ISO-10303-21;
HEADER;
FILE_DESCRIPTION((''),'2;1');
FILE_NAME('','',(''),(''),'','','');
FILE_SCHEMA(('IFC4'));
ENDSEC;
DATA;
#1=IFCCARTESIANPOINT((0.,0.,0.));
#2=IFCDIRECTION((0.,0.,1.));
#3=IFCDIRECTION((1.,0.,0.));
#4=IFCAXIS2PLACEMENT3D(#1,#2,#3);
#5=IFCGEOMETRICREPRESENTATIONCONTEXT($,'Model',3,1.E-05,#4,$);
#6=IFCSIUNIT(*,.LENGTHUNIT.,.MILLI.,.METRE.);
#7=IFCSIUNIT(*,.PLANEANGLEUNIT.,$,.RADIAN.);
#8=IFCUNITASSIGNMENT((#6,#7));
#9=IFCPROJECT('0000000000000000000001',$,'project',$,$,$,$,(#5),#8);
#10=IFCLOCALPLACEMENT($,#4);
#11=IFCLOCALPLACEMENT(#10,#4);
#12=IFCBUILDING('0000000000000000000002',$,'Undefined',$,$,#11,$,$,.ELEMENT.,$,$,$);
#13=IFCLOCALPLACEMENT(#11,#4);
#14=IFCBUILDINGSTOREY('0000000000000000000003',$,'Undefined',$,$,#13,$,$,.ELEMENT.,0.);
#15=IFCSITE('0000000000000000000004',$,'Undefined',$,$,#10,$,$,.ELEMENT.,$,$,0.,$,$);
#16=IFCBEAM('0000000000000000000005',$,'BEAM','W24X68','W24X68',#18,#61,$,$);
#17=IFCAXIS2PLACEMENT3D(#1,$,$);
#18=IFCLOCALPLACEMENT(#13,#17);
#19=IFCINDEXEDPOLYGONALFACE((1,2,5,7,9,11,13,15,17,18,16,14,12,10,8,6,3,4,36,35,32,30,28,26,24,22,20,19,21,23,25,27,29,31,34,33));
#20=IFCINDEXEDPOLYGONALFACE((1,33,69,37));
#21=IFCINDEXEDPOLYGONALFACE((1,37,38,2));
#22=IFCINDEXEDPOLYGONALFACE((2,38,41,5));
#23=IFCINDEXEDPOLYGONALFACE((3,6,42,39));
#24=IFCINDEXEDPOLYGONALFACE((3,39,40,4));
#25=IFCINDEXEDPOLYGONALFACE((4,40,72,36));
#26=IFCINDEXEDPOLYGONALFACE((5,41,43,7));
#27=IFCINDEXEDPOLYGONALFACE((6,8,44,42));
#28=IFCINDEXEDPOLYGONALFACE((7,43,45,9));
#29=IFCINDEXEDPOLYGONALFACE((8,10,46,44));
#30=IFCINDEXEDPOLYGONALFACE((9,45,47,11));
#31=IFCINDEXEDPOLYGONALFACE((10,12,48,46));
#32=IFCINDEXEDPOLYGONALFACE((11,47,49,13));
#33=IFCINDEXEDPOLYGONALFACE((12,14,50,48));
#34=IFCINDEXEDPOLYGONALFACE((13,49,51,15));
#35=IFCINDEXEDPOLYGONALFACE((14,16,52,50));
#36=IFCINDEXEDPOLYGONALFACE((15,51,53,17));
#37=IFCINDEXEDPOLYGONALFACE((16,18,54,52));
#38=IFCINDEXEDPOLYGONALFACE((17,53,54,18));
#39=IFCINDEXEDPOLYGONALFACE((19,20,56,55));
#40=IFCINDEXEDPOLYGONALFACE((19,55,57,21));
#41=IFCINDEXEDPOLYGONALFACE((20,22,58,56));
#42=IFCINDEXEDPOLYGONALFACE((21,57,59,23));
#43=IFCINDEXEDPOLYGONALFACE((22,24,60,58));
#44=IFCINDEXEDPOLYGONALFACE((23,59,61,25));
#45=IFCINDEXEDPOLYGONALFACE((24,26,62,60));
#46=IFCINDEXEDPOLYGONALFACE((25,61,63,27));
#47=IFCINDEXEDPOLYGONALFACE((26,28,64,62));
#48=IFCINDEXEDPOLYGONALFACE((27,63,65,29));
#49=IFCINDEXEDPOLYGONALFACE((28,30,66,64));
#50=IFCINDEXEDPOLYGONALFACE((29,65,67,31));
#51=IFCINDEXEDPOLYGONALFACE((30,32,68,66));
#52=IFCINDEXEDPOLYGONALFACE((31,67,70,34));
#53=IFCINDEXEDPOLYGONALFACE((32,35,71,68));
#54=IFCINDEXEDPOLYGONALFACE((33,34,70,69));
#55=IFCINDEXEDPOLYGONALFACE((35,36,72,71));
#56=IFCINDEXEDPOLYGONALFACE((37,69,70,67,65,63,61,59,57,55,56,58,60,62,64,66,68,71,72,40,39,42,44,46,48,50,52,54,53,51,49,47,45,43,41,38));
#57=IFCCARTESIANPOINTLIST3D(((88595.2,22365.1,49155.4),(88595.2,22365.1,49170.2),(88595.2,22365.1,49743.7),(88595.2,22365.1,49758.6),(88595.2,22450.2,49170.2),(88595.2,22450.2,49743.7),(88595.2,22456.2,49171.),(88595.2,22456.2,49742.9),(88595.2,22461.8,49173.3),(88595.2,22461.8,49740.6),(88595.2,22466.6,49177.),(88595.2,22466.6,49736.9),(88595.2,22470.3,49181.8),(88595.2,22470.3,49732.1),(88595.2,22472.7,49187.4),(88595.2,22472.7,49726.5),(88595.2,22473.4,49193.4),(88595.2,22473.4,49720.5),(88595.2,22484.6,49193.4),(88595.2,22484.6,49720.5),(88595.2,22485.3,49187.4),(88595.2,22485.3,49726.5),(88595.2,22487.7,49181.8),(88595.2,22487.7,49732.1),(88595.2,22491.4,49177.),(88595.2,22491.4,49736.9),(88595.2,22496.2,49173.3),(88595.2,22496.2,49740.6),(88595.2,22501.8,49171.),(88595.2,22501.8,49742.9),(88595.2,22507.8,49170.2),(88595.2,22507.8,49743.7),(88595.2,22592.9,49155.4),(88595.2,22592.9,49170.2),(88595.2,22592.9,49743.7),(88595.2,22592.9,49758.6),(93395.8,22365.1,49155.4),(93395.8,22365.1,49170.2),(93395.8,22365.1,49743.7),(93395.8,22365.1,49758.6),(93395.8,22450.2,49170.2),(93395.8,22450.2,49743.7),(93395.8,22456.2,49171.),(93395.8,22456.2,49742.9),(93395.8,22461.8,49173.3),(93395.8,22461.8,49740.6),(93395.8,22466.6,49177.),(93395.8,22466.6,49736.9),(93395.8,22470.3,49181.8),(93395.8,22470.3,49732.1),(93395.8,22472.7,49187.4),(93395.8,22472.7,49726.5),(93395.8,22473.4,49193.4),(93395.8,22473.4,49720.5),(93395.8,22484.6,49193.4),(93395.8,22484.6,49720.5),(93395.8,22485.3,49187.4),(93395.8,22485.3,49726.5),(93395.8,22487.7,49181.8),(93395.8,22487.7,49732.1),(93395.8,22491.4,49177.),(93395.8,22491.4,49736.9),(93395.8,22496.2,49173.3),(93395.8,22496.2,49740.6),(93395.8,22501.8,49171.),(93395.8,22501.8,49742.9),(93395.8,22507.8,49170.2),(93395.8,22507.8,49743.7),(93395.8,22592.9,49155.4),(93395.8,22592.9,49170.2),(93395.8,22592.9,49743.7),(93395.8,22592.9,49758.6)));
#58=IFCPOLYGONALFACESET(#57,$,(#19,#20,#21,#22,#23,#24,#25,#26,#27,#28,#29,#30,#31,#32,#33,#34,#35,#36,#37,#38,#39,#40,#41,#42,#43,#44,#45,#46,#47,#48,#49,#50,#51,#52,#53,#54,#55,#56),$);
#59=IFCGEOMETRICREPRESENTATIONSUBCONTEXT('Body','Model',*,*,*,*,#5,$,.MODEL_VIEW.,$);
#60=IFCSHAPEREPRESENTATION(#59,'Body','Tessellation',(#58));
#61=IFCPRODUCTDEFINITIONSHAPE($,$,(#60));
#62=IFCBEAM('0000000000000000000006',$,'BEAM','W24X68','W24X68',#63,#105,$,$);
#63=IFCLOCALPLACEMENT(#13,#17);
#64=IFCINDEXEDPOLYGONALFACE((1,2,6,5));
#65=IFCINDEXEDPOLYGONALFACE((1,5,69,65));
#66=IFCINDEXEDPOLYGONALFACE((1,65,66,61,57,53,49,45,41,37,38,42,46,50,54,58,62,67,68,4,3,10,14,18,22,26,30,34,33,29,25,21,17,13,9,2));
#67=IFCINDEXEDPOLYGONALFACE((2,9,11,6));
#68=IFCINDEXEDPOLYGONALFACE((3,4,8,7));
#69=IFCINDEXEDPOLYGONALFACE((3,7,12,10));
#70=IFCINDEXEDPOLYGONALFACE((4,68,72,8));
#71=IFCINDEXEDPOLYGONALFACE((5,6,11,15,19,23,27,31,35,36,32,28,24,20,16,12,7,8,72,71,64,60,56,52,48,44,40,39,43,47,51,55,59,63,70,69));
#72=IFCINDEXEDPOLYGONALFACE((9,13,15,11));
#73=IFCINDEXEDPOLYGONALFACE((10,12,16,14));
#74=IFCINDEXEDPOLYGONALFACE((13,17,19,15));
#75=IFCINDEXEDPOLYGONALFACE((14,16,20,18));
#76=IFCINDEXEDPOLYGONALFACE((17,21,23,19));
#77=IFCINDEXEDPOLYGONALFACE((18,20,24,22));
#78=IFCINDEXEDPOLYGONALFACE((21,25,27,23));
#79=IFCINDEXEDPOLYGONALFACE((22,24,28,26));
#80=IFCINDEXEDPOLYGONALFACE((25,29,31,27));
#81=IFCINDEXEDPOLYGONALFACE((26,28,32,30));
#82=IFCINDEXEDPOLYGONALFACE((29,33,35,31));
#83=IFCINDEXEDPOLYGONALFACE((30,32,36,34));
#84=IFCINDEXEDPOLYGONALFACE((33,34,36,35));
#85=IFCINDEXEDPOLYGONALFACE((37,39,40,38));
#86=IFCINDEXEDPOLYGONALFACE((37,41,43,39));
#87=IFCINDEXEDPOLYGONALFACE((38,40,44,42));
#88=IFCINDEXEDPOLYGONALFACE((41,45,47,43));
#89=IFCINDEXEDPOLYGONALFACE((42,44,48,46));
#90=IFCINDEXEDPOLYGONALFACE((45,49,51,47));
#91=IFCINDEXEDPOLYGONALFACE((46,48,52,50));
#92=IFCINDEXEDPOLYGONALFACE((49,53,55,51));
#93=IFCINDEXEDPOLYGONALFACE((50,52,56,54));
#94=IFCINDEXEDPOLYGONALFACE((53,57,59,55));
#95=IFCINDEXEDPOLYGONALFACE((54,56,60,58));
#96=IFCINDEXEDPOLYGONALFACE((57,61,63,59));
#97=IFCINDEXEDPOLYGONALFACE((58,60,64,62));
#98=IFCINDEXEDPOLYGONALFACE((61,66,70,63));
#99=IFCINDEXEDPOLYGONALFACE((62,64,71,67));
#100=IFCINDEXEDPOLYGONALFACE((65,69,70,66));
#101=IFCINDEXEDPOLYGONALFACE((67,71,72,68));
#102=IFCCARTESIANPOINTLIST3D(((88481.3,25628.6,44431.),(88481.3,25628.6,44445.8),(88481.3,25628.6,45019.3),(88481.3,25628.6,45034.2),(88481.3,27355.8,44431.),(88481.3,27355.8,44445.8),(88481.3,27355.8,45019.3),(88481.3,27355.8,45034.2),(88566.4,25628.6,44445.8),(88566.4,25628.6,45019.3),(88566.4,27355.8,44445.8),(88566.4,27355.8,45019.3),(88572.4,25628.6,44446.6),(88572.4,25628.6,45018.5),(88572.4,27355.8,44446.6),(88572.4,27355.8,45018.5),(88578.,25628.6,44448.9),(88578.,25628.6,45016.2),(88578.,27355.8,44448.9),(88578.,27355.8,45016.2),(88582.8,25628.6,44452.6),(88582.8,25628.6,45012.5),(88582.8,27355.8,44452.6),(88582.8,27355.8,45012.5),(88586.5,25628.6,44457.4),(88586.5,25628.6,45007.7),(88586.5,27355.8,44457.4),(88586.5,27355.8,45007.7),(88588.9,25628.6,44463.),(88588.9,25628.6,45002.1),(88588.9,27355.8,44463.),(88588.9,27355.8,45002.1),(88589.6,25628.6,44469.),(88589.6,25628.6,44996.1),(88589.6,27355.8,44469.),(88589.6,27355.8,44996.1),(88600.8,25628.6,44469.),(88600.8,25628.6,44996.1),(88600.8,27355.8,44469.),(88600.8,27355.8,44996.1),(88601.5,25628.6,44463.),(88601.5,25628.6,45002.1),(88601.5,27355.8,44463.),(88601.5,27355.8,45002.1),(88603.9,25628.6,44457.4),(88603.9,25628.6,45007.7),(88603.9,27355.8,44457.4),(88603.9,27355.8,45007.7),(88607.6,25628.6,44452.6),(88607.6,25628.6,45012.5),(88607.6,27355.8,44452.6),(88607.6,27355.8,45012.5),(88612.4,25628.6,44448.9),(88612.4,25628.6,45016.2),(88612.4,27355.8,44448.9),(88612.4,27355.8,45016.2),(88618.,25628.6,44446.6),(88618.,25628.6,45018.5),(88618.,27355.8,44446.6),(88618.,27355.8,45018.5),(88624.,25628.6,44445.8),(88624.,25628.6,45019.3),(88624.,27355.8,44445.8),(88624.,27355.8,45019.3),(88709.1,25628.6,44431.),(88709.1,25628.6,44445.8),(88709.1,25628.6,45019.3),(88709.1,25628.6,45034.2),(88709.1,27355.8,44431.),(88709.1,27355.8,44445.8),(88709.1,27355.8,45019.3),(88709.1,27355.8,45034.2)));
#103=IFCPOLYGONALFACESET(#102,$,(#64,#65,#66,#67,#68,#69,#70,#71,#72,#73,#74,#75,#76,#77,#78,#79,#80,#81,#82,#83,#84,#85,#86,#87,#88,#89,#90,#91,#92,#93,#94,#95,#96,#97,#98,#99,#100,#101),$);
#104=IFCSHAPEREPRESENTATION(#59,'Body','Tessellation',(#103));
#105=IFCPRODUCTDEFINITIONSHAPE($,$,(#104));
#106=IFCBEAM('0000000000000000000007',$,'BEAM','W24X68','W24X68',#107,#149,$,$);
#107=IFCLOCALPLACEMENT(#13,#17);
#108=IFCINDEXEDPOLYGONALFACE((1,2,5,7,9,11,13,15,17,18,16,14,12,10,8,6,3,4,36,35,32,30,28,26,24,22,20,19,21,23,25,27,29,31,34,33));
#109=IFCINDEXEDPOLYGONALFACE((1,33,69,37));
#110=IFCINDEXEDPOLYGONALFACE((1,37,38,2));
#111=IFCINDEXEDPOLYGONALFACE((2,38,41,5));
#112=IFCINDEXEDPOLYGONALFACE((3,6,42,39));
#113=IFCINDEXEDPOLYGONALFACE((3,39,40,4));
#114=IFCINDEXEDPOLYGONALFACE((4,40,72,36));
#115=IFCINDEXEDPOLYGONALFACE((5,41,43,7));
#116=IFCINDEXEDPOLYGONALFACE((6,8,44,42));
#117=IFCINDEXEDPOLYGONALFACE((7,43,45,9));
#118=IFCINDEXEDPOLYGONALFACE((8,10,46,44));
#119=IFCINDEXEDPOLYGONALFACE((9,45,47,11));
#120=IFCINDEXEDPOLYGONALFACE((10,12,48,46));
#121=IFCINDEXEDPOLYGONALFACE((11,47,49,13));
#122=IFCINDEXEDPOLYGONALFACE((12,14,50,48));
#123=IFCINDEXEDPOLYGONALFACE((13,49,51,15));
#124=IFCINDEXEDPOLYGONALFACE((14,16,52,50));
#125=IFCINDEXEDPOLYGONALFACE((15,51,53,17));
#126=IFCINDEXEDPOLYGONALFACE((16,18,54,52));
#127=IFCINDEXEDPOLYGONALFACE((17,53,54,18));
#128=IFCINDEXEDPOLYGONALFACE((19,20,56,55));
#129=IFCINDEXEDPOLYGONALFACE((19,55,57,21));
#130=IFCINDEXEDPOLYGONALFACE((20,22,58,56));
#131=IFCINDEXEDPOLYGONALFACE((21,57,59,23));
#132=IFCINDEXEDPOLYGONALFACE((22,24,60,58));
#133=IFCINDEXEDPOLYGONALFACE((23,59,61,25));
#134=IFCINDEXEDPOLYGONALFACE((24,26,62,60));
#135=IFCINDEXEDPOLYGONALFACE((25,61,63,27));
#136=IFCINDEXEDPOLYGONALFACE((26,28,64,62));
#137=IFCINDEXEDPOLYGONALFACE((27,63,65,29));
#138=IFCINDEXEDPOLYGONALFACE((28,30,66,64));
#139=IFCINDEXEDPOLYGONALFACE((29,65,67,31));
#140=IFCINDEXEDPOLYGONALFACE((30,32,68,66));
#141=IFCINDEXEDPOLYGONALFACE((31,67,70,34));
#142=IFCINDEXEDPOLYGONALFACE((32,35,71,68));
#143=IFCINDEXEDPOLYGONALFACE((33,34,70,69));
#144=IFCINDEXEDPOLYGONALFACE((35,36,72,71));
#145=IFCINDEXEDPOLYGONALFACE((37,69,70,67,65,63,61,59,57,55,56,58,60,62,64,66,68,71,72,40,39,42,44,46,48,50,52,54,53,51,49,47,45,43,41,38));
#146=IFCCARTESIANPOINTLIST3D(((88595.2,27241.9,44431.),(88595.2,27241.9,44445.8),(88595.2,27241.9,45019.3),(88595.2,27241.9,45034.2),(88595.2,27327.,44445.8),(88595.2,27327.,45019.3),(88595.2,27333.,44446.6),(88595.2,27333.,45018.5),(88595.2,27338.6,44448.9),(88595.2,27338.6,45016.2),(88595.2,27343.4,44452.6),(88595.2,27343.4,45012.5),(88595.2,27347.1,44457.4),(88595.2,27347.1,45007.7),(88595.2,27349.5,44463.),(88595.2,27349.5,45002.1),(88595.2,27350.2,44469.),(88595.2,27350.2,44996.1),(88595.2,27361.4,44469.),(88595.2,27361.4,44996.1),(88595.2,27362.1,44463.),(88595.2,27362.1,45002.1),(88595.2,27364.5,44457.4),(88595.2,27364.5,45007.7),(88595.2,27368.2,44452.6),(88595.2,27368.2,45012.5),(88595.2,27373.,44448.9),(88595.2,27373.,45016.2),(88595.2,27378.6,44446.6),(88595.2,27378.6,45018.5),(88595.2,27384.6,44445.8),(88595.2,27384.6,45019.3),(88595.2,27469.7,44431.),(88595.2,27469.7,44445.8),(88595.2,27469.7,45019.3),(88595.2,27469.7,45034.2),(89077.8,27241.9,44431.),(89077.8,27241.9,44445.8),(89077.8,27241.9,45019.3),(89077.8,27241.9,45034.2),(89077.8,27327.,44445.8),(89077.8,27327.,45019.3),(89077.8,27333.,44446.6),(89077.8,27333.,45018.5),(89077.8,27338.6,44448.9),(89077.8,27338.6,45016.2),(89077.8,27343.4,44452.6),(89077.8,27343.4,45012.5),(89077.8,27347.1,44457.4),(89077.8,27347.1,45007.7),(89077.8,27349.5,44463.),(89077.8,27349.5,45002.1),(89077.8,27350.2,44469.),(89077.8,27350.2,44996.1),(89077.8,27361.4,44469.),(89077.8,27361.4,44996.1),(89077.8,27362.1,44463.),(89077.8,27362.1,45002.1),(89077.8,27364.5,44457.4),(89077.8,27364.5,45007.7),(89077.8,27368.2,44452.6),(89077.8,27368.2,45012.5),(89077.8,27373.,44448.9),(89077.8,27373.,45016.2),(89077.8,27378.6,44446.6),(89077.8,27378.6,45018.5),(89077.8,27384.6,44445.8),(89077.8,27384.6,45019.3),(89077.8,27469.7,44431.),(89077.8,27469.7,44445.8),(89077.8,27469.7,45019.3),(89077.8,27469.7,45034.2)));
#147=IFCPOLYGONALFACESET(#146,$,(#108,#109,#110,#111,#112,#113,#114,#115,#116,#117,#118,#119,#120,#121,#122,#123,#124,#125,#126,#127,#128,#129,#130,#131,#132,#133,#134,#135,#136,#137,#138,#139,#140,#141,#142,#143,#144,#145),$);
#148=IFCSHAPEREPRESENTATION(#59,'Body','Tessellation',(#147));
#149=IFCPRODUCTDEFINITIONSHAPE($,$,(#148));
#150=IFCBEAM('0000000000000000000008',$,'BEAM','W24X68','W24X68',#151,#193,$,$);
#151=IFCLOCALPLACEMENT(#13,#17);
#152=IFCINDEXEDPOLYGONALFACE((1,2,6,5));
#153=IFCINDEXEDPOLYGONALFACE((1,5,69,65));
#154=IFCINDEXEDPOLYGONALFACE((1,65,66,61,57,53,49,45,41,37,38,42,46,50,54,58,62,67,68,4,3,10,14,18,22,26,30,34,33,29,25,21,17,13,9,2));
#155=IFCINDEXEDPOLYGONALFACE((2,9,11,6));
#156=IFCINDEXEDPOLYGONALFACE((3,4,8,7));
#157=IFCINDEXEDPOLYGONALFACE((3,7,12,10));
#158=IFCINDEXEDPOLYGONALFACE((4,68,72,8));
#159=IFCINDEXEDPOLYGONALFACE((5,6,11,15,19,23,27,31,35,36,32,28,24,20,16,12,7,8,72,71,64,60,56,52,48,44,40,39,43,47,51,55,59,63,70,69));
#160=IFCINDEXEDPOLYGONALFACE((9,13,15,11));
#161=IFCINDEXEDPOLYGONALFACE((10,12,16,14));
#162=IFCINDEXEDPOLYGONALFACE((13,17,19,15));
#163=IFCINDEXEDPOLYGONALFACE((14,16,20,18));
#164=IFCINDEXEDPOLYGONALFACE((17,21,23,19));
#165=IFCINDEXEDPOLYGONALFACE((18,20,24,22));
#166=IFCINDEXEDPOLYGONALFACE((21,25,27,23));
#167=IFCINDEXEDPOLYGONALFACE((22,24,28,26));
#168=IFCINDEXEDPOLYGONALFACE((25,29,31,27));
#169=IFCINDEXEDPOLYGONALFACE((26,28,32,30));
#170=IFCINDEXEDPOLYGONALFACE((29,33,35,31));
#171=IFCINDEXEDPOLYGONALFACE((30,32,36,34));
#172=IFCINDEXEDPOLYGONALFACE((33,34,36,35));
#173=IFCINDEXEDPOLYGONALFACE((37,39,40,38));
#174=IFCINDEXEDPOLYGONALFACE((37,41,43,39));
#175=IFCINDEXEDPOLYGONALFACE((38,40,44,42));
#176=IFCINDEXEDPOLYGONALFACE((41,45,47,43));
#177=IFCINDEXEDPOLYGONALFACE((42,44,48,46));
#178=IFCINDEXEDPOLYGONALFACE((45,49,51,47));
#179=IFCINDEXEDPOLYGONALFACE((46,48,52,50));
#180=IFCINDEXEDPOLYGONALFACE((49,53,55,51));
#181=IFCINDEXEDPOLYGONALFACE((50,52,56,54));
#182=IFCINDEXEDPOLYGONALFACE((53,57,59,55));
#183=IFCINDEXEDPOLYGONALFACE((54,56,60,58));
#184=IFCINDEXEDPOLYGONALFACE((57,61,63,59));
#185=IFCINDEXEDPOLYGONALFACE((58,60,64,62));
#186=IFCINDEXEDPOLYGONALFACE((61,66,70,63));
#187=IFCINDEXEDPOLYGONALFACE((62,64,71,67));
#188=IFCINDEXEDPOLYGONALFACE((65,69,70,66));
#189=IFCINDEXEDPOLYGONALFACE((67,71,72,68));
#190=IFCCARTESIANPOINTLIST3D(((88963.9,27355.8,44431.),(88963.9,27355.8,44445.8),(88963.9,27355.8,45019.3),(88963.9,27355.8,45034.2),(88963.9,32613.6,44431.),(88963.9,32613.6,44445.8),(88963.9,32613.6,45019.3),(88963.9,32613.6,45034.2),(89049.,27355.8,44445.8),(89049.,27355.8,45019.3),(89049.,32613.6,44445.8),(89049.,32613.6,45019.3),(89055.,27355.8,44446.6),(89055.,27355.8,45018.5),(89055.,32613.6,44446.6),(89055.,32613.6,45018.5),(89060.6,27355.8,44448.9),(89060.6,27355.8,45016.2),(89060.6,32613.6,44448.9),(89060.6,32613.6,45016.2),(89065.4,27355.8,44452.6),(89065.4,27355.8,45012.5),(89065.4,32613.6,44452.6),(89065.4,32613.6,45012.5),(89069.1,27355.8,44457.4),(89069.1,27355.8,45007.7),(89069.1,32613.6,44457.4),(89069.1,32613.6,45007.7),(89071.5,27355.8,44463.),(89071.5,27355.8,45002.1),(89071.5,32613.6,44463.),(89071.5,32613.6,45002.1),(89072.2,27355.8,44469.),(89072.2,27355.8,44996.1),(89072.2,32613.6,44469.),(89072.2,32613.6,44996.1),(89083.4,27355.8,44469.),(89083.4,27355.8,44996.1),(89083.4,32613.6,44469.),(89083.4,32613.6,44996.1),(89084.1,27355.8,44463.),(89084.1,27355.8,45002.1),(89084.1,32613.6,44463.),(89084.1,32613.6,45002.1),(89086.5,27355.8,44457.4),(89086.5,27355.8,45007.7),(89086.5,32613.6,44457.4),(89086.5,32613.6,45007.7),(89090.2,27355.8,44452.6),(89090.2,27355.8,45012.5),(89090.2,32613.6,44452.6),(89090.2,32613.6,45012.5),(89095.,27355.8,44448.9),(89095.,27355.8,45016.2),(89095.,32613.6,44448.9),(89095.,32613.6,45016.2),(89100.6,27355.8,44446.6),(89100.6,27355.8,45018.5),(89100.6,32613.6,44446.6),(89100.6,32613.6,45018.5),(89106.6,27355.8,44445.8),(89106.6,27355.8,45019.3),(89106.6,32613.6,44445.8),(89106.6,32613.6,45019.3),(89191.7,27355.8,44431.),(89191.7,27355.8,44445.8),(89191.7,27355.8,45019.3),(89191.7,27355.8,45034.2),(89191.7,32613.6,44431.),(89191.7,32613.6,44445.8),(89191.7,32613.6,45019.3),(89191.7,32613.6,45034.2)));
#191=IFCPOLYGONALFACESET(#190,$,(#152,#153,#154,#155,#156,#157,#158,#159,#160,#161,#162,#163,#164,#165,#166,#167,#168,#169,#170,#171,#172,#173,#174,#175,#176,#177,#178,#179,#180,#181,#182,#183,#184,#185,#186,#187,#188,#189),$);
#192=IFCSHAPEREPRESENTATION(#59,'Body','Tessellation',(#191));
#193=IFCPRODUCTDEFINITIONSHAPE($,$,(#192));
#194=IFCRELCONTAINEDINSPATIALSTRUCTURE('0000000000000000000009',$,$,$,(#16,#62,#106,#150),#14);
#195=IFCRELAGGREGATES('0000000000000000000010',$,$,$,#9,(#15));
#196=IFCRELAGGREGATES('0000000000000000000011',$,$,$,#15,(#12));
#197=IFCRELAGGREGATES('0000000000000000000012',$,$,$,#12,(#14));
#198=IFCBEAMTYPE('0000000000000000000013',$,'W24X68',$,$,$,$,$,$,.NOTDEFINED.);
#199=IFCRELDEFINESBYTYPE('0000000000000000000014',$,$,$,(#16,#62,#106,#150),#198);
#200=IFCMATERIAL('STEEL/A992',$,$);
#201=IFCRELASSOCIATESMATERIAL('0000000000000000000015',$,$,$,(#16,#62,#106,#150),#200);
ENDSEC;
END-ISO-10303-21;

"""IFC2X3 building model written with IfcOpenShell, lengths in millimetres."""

from ifc_helpers import new_model, si_unit, frame, origin_with_axes, origin_2d_with_axis, place, context, subcontext, project, spatial, i_section, extrude, material, type_object, element, save


model = new_model("IFC2X3")

# Units and contexts
model_context = context("Model", 3, precision=1e-05, world=origin_with_axes())
body_context = subcontext(model_context, "Body", "Model", "MODEL_VIEW")
ifc_project = project(units=[si_unit("LENGTHUNIT", "METRE", prefix="MILLI"), si_unit("PLANEANGLEUNIT", "RADIAN")], contexts=[model_context])

# Site, building, storey
site_placement = place(None, origin_with_axes())
site = spatial("IfcSite", under=ifc_project, at=site_placement, Name="Undefined", CompositionType="ELEMENT", RefElevation=0.0)
building_placement = place(site_placement, origin_with_axes())
building = spatial("IfcBuilding", under=site, at=building_placement, Name="Undefined", CompositionType="ELEMENT")
storey_placement = place(building_placement, origin_with_axes())
storey = spatial("IfcBuildingStorey", under=building, at=storey_placement, Name="Undefined", CompositionType="ELEMENT", Elevation=0.0)

# Shared definitions
ifc_material = material(Name="STEEL/A992")

# Beams
beam_type = type_object("IfcBeamType", Name="W24X68", PredefinedType="NOTDEFINED")
beam_1_placement = place(storey_placement, frame((88595.2, 22479.0, 49457.0), z_axis=(0.0, 0.0, 1.0), x_axis=(1.0, 0.0, 0.0)))
element("IfcBeam", 1, at=beam_1_placement, inside=storey, type_object=beam_type, material=ifc_material, Name="BEAM", Description="W24X68", ObjectType="W24X68", context=body_context, shape_type="SweptSolid", body=[
    extrude(i_section(OverallWidth=227.8, OverallDepth=603.2, WebThickness=11.1, FlangeThickness=14.9, FilletRadius=23.2, at=origin_2d_with_axis()), frame((4800.6, 0.0, 0.0), z_axis=(-1.0, 0.0, 0.0), x_axis=(0.0, -1.0, 0.0)), (0.0, 0.0, 1.0), 4800.6),
])
beam_2_placement = place(storey_placement, frame((88595.2, 25628.6, 44732.6), z_axis=(0.0, 0.0, 1.0), x_axis=(0.0, 1.0, 0.0)))
element("IfcBeam", 2, at=beam_2_placement, inside=storey, type_object=beam_type, material=ifc_material, Name="BEAM", Description="W24X68", ObjectType="W24X68", context=body_context, shape_type="SweptSolid", body=[
    extrude(i_section(OverallWidth=227.8, OverallDepth=603.2, WebThickness=11.1, FlangeThickness=14.9, FilletRadius=23.2, at=origin_2d_with_axis()), frame((1727.2, 0.0, 0.0), z_axis=(-1.0, 0.0, 0.0), x_axis=(0.0, -1.0, 0.0)), (0.0, 0.0, 1.0), 1727.2),
])
beam_3_placement = place(storey_placement, frame((88595.2, 27355.8, 44732.6), z_axis=(0.0, 0.0, 1.0), x_axis=(1.0, 0.0, 0.0)))
element("IfcBeam", 3, at=beam_3_placement, inside=storey, type_object=beam_type, material=ifc_material, Name="BEAM", Description="W24X68", ObjectType="W24X68", context=body_context, shape_type="SweptSolid", body=[
    extrude(i_section(OverallWidth=227.8, OverallDepth=603.2, WebThickness=11.1, FlangeThickness=14.9, FilletRadius=23.2, at=origin_2d_with_axis()), frame((482.6, 0.0, 0.0), z_axis=(-1.0, 0.0, 0.0), x_axis=(0.0, -1.0, 0.0)), (0.0, 0.0, 1.0), 482.6),
])
beam_4_placement = place(storey_placement, frame((89077.8, 27355.8, 44732.6), z_axis=(0.0, 0.0, 1.0), x_axis=(0.0, 1.0, 0.0)))
element("IfcBeam", 4, at=beam_4_placement, inside=storey, type_object=beam_type, material=ifc_material, Name="BEAM", Description="W24X68", ObjectType="W24X68", context=body_context, shape_type="SweptSolid", body=[
    extrude(i_section(OverallWidth=227.8, OverallDepth=603.2, WebThickness=11.1, FlangeThickness=14.9, FilletRadius=23.2, at=origin_2d_with_axis()), frame((5257.8, 0.0, 0.0), z_axis=(-1.0, 0.0, 0.0), x_axis=(0.0, -1.0, 0.0)), (0.0, 0.0, 1.0), 5257.8),
])

save(model, "model.ifc")
